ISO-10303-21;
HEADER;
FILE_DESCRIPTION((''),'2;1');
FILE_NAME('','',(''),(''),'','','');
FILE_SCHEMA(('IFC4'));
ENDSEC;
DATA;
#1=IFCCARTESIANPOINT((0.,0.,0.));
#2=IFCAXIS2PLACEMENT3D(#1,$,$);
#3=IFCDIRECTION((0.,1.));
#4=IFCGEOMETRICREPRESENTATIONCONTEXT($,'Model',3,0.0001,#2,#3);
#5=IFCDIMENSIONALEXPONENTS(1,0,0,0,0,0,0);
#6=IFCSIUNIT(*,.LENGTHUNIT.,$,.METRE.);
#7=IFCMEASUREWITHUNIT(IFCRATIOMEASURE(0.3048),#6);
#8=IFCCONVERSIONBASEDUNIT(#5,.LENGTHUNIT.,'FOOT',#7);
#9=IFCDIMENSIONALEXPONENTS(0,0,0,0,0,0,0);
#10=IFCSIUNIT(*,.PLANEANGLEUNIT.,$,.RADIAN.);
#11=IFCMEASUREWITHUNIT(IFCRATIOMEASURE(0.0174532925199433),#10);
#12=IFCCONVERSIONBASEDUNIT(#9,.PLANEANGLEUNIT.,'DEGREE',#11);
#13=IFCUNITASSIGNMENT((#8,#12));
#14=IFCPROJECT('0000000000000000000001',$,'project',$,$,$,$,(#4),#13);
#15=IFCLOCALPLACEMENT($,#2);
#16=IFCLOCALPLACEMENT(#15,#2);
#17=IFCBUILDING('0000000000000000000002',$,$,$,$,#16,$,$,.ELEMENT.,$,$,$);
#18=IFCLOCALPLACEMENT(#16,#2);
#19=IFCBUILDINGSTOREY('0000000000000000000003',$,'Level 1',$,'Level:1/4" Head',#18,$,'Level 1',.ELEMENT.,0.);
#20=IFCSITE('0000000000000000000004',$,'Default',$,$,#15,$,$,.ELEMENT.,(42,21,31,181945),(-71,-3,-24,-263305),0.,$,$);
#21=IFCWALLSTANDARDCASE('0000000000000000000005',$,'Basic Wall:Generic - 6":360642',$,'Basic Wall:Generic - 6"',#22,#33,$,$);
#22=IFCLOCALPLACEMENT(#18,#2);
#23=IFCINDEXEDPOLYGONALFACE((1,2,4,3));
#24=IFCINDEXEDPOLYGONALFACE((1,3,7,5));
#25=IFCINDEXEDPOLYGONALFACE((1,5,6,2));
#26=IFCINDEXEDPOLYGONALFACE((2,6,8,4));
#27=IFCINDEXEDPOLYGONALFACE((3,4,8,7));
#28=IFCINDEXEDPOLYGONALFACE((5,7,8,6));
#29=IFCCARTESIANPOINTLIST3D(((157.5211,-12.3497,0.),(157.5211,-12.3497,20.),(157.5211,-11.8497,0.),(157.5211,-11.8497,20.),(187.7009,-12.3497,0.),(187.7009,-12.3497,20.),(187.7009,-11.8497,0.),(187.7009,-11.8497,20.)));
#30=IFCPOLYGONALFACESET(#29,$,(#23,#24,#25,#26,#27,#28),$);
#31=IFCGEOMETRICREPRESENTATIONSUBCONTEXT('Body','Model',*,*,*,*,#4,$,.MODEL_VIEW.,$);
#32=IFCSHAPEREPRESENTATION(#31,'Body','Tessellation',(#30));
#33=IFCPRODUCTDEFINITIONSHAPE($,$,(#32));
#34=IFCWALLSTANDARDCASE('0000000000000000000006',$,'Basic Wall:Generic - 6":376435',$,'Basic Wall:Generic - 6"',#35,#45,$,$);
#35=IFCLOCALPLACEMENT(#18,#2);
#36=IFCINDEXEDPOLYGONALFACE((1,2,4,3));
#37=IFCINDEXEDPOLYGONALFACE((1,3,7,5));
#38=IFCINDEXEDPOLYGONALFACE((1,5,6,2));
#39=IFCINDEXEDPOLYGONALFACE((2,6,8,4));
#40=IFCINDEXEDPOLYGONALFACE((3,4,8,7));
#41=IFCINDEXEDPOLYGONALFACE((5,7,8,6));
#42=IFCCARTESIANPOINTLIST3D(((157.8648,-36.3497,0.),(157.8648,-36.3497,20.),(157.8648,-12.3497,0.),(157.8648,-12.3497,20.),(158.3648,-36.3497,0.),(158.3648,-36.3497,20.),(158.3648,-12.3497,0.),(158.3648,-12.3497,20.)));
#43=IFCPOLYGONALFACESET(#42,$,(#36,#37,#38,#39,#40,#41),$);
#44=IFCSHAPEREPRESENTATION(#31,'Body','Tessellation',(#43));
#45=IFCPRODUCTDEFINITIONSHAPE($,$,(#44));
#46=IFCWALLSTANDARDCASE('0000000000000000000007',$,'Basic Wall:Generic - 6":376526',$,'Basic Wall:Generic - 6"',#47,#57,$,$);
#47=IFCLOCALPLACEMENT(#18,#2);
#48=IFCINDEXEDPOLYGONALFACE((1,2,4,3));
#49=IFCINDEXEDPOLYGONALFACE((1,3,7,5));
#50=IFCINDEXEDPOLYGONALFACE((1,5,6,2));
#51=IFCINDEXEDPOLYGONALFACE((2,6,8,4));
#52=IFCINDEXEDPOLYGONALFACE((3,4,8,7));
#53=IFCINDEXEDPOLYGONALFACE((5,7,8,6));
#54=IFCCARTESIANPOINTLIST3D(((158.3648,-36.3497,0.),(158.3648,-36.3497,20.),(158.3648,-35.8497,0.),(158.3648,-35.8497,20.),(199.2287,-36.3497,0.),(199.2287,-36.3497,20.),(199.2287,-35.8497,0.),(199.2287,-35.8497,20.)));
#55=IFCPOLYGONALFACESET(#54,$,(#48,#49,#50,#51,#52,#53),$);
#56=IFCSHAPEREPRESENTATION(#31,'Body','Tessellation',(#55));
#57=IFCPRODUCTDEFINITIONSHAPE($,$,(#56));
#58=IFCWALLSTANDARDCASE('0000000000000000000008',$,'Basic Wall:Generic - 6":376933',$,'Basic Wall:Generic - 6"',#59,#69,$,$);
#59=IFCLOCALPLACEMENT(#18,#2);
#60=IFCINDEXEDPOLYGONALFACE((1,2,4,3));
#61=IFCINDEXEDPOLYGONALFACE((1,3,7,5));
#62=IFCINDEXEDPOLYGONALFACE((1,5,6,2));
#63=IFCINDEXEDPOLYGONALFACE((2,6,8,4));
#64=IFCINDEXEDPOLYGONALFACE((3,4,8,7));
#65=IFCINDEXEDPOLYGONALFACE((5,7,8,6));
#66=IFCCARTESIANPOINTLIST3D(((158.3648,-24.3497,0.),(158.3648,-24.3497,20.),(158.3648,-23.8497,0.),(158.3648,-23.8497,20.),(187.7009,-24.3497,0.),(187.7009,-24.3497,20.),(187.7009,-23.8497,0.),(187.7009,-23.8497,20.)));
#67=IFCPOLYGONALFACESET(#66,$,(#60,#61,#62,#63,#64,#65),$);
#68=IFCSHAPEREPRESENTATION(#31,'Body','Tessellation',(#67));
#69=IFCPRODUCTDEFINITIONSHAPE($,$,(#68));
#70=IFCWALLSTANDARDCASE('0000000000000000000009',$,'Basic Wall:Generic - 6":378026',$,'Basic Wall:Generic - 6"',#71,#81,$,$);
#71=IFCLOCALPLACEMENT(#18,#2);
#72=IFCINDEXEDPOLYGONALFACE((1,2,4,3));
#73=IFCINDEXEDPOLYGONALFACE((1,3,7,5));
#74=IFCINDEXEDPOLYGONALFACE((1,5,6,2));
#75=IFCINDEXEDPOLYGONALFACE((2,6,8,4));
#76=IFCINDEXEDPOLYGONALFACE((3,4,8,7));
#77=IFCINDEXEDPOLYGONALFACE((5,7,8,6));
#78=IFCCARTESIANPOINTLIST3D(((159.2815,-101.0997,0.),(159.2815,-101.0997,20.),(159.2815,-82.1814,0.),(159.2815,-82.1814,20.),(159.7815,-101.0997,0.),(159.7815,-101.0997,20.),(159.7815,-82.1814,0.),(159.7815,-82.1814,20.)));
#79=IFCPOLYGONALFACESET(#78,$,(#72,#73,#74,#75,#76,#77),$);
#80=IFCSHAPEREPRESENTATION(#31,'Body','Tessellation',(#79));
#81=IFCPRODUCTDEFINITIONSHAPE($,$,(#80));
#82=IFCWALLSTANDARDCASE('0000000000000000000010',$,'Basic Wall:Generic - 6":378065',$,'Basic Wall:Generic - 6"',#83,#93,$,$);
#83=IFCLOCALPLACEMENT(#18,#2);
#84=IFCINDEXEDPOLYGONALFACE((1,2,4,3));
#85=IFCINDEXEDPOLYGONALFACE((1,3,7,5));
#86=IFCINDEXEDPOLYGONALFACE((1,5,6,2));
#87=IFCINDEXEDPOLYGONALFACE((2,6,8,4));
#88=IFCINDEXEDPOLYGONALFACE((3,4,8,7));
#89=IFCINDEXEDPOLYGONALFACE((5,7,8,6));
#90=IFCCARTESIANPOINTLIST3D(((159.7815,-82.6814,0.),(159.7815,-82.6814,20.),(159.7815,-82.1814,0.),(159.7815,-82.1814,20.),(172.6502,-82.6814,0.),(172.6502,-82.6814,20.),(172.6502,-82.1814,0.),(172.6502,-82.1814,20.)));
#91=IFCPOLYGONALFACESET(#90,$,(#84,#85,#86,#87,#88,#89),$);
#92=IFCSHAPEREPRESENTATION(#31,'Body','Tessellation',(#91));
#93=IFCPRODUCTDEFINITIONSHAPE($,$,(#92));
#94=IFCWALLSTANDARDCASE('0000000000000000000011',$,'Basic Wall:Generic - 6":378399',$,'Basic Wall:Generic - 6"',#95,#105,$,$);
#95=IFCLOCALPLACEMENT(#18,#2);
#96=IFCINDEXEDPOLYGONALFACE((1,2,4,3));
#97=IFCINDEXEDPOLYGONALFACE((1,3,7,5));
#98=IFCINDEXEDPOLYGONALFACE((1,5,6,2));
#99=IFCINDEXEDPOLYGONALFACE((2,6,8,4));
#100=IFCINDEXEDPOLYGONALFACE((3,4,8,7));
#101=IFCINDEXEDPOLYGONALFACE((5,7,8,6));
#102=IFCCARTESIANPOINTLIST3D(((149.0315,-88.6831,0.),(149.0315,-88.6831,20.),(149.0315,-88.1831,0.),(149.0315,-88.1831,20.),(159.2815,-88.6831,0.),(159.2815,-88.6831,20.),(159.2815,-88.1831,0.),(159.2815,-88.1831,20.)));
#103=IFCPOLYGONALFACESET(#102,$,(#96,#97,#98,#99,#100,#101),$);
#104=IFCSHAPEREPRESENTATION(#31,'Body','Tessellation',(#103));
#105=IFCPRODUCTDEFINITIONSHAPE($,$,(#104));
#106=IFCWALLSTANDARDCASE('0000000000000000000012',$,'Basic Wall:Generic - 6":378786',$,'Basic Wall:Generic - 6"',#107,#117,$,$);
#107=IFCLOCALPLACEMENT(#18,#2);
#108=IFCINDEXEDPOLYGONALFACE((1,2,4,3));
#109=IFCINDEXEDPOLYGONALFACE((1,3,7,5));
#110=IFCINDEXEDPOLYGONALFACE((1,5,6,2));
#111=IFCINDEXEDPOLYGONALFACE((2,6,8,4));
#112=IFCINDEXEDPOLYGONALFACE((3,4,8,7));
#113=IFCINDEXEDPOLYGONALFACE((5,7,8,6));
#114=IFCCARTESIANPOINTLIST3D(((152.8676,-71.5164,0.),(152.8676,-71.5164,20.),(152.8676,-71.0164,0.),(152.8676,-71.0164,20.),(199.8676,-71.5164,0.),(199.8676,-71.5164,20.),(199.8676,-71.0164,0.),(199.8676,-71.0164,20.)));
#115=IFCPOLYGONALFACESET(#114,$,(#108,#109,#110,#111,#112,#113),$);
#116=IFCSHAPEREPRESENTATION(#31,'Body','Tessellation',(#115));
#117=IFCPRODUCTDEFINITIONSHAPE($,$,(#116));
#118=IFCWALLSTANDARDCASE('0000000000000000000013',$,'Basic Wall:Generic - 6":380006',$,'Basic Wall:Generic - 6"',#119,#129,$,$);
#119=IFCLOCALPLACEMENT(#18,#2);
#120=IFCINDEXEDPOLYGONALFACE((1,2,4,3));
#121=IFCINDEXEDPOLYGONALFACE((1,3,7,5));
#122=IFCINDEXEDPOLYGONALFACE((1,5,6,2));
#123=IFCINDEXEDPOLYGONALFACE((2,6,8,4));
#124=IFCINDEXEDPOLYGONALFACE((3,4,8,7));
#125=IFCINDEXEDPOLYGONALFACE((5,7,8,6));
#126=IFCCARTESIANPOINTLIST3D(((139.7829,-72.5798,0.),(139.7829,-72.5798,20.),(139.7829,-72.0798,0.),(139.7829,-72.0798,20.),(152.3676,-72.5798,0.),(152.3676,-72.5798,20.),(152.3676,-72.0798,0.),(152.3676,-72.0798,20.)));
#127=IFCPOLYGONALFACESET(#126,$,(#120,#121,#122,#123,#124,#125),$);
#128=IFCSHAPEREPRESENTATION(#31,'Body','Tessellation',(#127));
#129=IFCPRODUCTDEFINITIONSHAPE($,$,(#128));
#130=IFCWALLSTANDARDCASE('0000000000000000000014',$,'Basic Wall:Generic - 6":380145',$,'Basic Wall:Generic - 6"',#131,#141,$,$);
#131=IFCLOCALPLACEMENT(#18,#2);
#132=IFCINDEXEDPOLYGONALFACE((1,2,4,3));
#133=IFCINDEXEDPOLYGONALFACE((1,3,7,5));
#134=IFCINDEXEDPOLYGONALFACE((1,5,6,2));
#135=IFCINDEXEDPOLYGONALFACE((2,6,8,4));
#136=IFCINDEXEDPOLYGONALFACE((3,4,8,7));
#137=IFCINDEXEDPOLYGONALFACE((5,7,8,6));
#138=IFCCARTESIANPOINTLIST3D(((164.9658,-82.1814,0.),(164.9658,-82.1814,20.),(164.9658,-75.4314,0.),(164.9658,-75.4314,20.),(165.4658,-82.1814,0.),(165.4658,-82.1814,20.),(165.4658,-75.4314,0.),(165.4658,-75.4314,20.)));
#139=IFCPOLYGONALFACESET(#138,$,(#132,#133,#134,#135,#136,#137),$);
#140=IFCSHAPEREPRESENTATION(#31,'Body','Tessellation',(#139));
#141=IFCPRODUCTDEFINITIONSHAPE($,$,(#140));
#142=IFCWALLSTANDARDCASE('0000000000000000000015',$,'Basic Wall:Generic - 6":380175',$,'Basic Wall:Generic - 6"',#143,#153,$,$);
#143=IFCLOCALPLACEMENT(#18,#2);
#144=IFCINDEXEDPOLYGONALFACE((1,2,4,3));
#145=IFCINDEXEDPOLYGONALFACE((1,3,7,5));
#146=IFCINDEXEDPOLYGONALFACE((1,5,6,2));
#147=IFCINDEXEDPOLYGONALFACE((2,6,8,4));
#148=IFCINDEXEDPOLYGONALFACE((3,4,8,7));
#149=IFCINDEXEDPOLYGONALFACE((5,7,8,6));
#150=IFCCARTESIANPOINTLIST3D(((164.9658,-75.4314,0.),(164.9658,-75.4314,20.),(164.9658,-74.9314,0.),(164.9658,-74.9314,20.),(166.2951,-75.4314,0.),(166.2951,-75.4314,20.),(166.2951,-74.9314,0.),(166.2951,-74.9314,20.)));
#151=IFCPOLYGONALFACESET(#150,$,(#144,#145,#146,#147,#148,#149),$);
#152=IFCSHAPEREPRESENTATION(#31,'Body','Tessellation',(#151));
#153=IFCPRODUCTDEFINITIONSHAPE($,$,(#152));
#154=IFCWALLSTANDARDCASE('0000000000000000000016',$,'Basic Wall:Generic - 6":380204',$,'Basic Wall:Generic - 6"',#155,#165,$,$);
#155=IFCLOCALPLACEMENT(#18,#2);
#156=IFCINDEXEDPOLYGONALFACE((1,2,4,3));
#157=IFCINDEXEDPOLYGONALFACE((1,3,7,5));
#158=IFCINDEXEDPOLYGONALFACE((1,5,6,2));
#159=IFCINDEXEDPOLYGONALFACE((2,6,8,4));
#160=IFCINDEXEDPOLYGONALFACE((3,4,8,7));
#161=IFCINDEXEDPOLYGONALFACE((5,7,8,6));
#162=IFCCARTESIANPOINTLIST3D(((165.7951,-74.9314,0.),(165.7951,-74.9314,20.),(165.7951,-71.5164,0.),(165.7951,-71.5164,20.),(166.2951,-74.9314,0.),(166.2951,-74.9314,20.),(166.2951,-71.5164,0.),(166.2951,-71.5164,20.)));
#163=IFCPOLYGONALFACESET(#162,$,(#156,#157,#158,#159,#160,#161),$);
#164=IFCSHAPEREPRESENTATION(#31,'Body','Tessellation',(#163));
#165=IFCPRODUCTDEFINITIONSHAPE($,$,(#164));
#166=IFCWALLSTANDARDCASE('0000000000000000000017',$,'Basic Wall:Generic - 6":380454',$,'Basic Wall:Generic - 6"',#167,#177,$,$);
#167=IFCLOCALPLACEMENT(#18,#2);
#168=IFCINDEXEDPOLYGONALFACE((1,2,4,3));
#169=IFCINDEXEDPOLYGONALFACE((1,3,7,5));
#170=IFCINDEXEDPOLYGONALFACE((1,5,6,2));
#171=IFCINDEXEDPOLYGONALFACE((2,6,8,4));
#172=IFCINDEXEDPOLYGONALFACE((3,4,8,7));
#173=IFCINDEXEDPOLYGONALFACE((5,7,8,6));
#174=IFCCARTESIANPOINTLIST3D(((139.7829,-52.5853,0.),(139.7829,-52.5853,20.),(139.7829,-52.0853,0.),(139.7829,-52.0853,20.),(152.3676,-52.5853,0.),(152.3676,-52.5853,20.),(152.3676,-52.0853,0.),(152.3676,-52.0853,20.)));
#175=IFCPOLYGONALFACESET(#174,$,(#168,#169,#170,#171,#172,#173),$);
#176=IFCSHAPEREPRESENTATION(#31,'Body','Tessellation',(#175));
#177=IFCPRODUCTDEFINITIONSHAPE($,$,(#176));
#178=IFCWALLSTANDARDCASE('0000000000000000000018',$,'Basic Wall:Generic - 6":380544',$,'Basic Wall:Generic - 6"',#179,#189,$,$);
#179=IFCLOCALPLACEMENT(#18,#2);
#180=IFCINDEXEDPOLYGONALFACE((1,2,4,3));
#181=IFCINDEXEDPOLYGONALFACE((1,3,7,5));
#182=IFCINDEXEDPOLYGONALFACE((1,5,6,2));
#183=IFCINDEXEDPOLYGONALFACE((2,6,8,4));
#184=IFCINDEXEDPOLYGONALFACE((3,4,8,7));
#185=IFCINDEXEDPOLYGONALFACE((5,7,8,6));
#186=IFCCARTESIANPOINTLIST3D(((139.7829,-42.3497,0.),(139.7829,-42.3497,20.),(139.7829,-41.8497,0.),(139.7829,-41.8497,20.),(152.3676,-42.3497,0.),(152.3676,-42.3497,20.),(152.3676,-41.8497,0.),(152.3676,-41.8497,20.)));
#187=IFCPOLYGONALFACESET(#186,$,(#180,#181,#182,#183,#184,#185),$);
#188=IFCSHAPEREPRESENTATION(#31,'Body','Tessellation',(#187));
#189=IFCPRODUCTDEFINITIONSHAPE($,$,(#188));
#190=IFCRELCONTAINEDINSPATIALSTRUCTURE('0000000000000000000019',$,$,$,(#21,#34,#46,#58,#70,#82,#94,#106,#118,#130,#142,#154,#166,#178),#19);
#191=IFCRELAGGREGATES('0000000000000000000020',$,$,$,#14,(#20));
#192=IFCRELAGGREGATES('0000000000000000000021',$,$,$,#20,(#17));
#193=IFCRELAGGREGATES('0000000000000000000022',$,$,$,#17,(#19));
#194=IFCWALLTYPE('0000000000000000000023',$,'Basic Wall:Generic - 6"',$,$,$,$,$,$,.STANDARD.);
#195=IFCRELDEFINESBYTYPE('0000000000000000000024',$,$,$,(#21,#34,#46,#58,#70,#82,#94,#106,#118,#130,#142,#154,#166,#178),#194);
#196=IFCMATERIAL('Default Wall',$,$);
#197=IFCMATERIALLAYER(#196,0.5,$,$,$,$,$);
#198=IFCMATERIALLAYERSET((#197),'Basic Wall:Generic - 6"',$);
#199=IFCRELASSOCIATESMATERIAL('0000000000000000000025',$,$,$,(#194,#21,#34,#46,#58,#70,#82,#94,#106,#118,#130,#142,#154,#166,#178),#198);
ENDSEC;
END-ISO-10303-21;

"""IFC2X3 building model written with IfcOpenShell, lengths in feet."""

from ifc_helpers import new_model, entity, si_unit, converted_unit, direction, frame, frame_2d, origin, place, context, subcontext, project, spatial, rectangle, extrude, material, layer, layer_set, layer_usage, type_object, element, save


model = new_model("IFC2X3")

# Units and contexts
model_context = context("Model", 3, precision=0.0001, world=origin(), true_north=direction((0.0, 1.0)))
body_context = subcontext(model_context, "Body", "Model", "MODEL_VIEW")
ifc_project = project(units=[converted_unit("LENGTHUNIT", "FOOT", entity("IfcRatioMeasure", 0.3048), si_unit("LENGTHUNIT", "METRE"), dimensions=[1, 0, 0, 0, 0, 0, 0]), converted_unit("PLANEANGLEUNIT", "DEGREE", entity("IfcRatioMeasure", 0.0174532925199433), si_unit("PLANEANGLEUNIT", "RADIAN"), dimensions=[0, 0, 0, 0, 0, 0, 0])], contexts=[model_context])

# Site, building, storey
site_placement = place(None, origin())
site = spatial("IfcSite", under=ifc_project, at=site_placement, Name="Default", CompositionType="ELEMENT", RefLatitude=(42, 21, 31, 181945), RefLongitude=(-71, -3, -24, -263305), RefElevation=0.0)
building_placement = place(site_placement, origin())
building = spatial("IfcBuilding", under=site, at=building_placement, CompositionType="ELEMENT")
storey_placement = place(building_placement, origin())
storey = spatial("IfcBuildingStorey", under=building, at=storey_placement, Name="Level 1", ObjectType="Level:1/4\" Head", LongName="Level 1", CompositionType="ELEMENT", Elevation=0.0)

# Walls
ifc_material = material(Name="Default Wall")
ifc_layer = layer(ifc_material, 0.5)
ifc_layer_set = layer_set([ifc_layer], Name="Basic Wall:Generic - 6\"")
ifc_layer_usage_1 = layer_usage(ifc_layer_set, "AXIS2", "NEGATIVE", 0.25)
wall_type = type_object("IfcWallType", Name="Basic Wall:Generic - 6\"", PredefinedType="STANDARD", material=ifc_layer_set)
wall_1_placement = place(storey_placement, frame((157.5211, -12.0997, 0.0)))
element("IfcWallStandardCase", 1, at=wall_1_placement, inside=storey, type_object=wall_type, material=ifc_layer_usage_1, Name="Basic Wall:Generic - 6\":360642", ObjectType="Basic Wall:Generic - 6\"", context=body_context, shape_type="SweptSolid", body=[
    extrude(rectangle(XDim=30.1799, YDim=0.5, at=frame_2d((15.0899, 0.0), x_axis=(-1.0, 0.0))), origin(), (0.0, 0.0, 1.0), 20.0),
])
ifc_layer_usage_2 = layer_usage(ifc_layer_set, "AXIS2", "NEGATIVE", 0.25)
wall_2_placement = place(storey_placement, frame((158.1148, -12.3497, 0.0), z_axis=(0.0, 0.0, 1.0), x_axis=(0.0, -1.0, 0.0)))
element("IfcWallStandardCase", 2, at=wall_2_placement, inside=storey, type_object=wall_type, material=ifc_layer_usage_2, Name="Basic Wall:Generic - 6\":376435", ObjectType="Basic Wall:Generic - 6\"", context=body_context, shape_type="SweptSolid", body=[
    extrude(rectangle(XDim=24.0, YDim=0.5, at=frame_2d((12.0, 0.0), x_axis=(-1.0, 0.0))), origin(), (0.0, 0.0, 1.0), 20.0),
])
ifc_layer_usage_3 = layer_usage(ifc_layer_set, "AXIS2", "NEGATIVE", 0.25)
wall_3_placement = place(storey_placement, frame((158.3648, -36.0997, 0.0)))
element("IfcWallStandardCase", 3, at=wall_3_placement, inside=storey, type_object=wall_type, material=ifc_layer_usage_3, Name="Basic Wall:Generic - 6\":376526", ObjectType="Basic Wall:Generic - 6\"", context=body_context, shape_type="SweptSolid", body=[
    extrude(rectangle(XDim=40.8639, YDim=0.5, at=frame_2d((20.4319, 0.0), x_axis=(-1.0, 0.0))), origin(), (0.0, 0.0, 1.0), 20.0),
])
ifc_layer_usage_4 = layer_usage(ifc_layer_set, "AXIS2", "NEGATIVE", 0.25)
wall_4_placement = place(storey_placement, frame((158.3648, -24.0997, 0.0)))
element("IfcWallStandardCase", 4, at=wall_4_placement, inside=storey, type_object=wall_type, material=ifc_layer_usage_4, Name="Basic Wall:Generic - 6\":376933", ObjectType="Basic Wall:Generic - 6\"", context=body_context, shape_type="SweptSolid", body=[
    extrude(rectangle(XDim=29.3361, YDim=0.5, at=frame_2d((14.6681, 0.0), x_axis=(-1.0, 0.0))), origin(), (0.0, 0.0, 1.0), 20.0),
])
ifc_layer_usage_5 = layer_usage(ifc_layer_set, "AXIS2", "NEGATIVE", 0.25)
wall_5_placement = place(storey_placement, frame((159.5315, -101.0997, 0.0), z_axis=(0.0, 0.0, 1.0), x_axis=(0.0, 1.0, 0.0)))
element("IfcWallStandardCase", 5, at=wall_5_placement, inside=storey, type_object=wall_type, material=ifc_layer_usage_5, Name="Basic Wall:Generic - 6\":378026", ObjectType="Basic Wall:Generic - 6\"", context=body_context, shape_type="SweptSolid", body=[
    extrude(rectangle(XDim=18.9183, YDim=0.5, at=frame_2d((9.4592, 0.0), x_axis=(-1.0, 0.0))), origin(), (0.0, 0.0, 1.0), 20.0),
])
ifc_layer_usage_6 = layer_usage(ifc_layer_set, "AXIS2", "NEGATIVE", 0.25)
wall_6_placement = place(storey_placement, frame((159.7815, -82.4314, 0.0)))
element("IfcWallStandardCase", 6, at=wall_6_placement, inside=storey, type_object=wall_type, material=ifc_layer_usage_6, Name="Basic Wall:Generic - 6\":378065", ObjectType="Basic Wall:Generic - 6\"", context=body_context, shape_type="SweptSolid", body=[
    extrude(rectangle(XDim=12.8687, YDim=0.5, at=frame_2d((6.4343, 0.0), x_axis=(-1.0, 0.0))), origin(), (0.0, 0.0, 1.0), 20.0),
])
ifc_layer_usage_7 = layer_usage(ifc_layer_set, "AXIS2", "NEGATIVE", 0.25)
wall_7_placement = place(storey_placement, frame((149.0315, -88.4331, 0.0)))
element("IfcWallStandardCase", 7, at=wall_7_placement, inside=storey, type_object=wall_type, material=ifc_layer_usage_7, Name="Basic Wall:Generic - 6\":378399", ObjectType="Basic Wall:Generic - 6\"", context=body_context, shape_type="SweptSolid", body=[
    extrude(rectangle(XDim=10.25, YDim=0.5, at=frame_2d((5.125, 0.0), x_axis=(-1.0, 0.0))), origin(), (0.0, 0.0, 1.0), 20.0),
])
ifc_layer_usage_8 = layer_usage(ifc_layer_set, "AXIS2", "NEGATIVE", 0.25)
wall_8_placement = place(storey_placement, frame((152.8676, -71.2664, 0.0)))
element("IfcWallStandardCase", 8, at=wall_8_placement, inside=storey, type_object=wall_type, material=ifc_layer_usage_8, Name="Basic Wall:Generic - 6\":378786", ObjectType="Basic Wall:Generic - 6\"", context=body_context, shape_type="SweptSolid", body=[
    extrude(rectangle(XDim=47.0, YDim=0.5, at=frame_2d((23.5, 0.0), x_axis=(-1.0, 0.0))), origin(), (0.0, 0.0, 1.0), 20.0),
])
ifc_layer_usage_9 = layer_usage(ifc_layer_set, "AXIS2", "NEGATIVE", 0.25)
wall_9_placement = place(storey_placement, frame((152.3676, -72.3298, 0.0), z_axis=(0.0, 0.0, 1.0), x_axis=(-1.0, 0.0, 0.0)))
element("IfcWallStandardCase", 9, at=wall_9_placement, inside=storey, type_object=wall_type, material=ifc_layer_usage_9, Name="Basic Wall:Generic - 6\":380006", ObjectType="Basic Wall:Generic - 6\"", context=body_context, shape_type="SweptSolid", body=[
    extrude(rectangle(XDim=12.5847, YDim=0.5, at=frame_2d((6.2924, 0.0), x_axis=(-1.0, 0.0))), origin(), (0.0, 0.0, 1.0), 20.0),
])
ifc_layer_usage_10 = layer_usage(ifc_layer_set, "AXIS2", "NEGATIVE", 0.25)
wall_10_placement = place(storey_placement, frame((165.2158, -82.1814, 0.0), z_axis=(0.0, 0.0, 1.0), x_axis=(0.0, 1.0, 0.0)))
element("IfcWallStandardCase", 10, at=wall_10_placement, inside=storey, type_object=wall_type, material=ifc_layer_usage_10, Name="Basic Wall:Generic - 6\":380145", ObjectType="Basic Wall:Generic - 6\"", context=body_context, shape_type="SweptSolid", body=[
    extrude(rectangle(XDim=6.75, YDim=0.5, at=frame_2d((3.375, 0.0), x_axis=(-1.0, 0.0))), origin(), (0.0, 0.0, 1.0), 20.0),
])
ifc_layer_usage_11 = layer_usage(ifc_layer_set, "AXIS2", "NEGATIVE", 0.25)
wall_11_placement = place(storey_placement, frame((164.9658, -75.1814, 0.0)))
element("IfcWallStandardCase", 11, at=wall_11_placement, inside=storey, type_object=wall_type, material=ifc_layer_usage_11, Name="Basic Wall:Generic - 6\":380175", ObjectType="Basic Wall:Generic - 6\"", context=body_context, shape_type="SweptSolid", body=[
    extrude(rectangle(XDim=1.3292, YDim=0.5, at=frame_2d((0.6646, 0.0), x_axis=(-1.0, 0.0))), origin(), (0.0, 0.0, 1.0), 20.0),
])
ifc_layer_usage_12 = layer_usage(ifc_layer_set, "AXIS2", "NEGATIVE", 0.25)
wall_12_placement = place(storey_placement, frame((166.0451, -74.9314, 0.0), z_axis=(0.0, 0.0, 1.0), x_axis=(0.0, 1.0, 0.0)))
element("IfcWallStandardCase", 12, at=wall_12_placement, inside=storey, type_object=wall_type, material=ifc_layer_usage_12, Name="Basic Wall:Generic - 6\":380204", ObjectType="Basic Wall:Generic - 6\"", context=body_context, shape_type="SweptSolid", body=[
    extrude(rectangle(XDim=3.415, YDim=0.5, at=frame_2d((1.7075, 0.0), x_axis=(-1.0, 0.0))), origin(), (0.0, 0.0, 1.0), 20.0),
])
ifc_layer_usage_13 = layer_usage(ifc_layer_set, "AXIS2", "NEGATIVE", 0.25)
wall_13_placement = place(storey_placement, frame((152.3676, -52.3353, 0.0), z_axis=(0.0, 0.0, 1.0), x_axis=(-1.0, 0.0, 0.0)))
element("IfcWallStandardCase", 13, at=wall_13_placement, inside=storey, type_object=wall_type, material=ifc_layer_usage_13, Name="Basic Wall:Generic - 6\":380454", ObjectType="Basic Wall:Generic - 6\"", context=body_context, shape_type="SweptSolid", body=[
    extrude(rectangle(XDim=12.5847, YDim=0.5, at=frame_2d((6.2924, 0.0), x_axis=(-1.0, 0.0))), origin(), (0.0, 0.0, 1.0), 20.0),
])
ifc_layer_usage_14 = layer_usage(ifc_layer_set, "AXIS2", "NEGATIVE", 0.25)
wall_14_placement = place(storey_placement, frame((152.3676, -42.0997, 0.0), z_axis=(0.0, 0.0, 1.0), x_axis=(-1.0, 0.0, 0.0)))
element("IfcWallStandardCase", 14, at=wall_14_placement, inside=storey, type_object=wall_type, material=ifc_layer_usage_14, Name="Basic Wall:Generic - 6\":380544", ObjectType="Basic Wall:Generic - 6\"", context=body_context, shape_type="SweptSolid", body=[
    extrude(rectangle(XDim=12.5847, YDim=0.5, at=frame_2d((6.2924, 0.0), x_axis=(-1.0, 0.0))), origin(), (0.0, 0.0, 1.0), 20.0),
])

save(model, "model.ifc")
